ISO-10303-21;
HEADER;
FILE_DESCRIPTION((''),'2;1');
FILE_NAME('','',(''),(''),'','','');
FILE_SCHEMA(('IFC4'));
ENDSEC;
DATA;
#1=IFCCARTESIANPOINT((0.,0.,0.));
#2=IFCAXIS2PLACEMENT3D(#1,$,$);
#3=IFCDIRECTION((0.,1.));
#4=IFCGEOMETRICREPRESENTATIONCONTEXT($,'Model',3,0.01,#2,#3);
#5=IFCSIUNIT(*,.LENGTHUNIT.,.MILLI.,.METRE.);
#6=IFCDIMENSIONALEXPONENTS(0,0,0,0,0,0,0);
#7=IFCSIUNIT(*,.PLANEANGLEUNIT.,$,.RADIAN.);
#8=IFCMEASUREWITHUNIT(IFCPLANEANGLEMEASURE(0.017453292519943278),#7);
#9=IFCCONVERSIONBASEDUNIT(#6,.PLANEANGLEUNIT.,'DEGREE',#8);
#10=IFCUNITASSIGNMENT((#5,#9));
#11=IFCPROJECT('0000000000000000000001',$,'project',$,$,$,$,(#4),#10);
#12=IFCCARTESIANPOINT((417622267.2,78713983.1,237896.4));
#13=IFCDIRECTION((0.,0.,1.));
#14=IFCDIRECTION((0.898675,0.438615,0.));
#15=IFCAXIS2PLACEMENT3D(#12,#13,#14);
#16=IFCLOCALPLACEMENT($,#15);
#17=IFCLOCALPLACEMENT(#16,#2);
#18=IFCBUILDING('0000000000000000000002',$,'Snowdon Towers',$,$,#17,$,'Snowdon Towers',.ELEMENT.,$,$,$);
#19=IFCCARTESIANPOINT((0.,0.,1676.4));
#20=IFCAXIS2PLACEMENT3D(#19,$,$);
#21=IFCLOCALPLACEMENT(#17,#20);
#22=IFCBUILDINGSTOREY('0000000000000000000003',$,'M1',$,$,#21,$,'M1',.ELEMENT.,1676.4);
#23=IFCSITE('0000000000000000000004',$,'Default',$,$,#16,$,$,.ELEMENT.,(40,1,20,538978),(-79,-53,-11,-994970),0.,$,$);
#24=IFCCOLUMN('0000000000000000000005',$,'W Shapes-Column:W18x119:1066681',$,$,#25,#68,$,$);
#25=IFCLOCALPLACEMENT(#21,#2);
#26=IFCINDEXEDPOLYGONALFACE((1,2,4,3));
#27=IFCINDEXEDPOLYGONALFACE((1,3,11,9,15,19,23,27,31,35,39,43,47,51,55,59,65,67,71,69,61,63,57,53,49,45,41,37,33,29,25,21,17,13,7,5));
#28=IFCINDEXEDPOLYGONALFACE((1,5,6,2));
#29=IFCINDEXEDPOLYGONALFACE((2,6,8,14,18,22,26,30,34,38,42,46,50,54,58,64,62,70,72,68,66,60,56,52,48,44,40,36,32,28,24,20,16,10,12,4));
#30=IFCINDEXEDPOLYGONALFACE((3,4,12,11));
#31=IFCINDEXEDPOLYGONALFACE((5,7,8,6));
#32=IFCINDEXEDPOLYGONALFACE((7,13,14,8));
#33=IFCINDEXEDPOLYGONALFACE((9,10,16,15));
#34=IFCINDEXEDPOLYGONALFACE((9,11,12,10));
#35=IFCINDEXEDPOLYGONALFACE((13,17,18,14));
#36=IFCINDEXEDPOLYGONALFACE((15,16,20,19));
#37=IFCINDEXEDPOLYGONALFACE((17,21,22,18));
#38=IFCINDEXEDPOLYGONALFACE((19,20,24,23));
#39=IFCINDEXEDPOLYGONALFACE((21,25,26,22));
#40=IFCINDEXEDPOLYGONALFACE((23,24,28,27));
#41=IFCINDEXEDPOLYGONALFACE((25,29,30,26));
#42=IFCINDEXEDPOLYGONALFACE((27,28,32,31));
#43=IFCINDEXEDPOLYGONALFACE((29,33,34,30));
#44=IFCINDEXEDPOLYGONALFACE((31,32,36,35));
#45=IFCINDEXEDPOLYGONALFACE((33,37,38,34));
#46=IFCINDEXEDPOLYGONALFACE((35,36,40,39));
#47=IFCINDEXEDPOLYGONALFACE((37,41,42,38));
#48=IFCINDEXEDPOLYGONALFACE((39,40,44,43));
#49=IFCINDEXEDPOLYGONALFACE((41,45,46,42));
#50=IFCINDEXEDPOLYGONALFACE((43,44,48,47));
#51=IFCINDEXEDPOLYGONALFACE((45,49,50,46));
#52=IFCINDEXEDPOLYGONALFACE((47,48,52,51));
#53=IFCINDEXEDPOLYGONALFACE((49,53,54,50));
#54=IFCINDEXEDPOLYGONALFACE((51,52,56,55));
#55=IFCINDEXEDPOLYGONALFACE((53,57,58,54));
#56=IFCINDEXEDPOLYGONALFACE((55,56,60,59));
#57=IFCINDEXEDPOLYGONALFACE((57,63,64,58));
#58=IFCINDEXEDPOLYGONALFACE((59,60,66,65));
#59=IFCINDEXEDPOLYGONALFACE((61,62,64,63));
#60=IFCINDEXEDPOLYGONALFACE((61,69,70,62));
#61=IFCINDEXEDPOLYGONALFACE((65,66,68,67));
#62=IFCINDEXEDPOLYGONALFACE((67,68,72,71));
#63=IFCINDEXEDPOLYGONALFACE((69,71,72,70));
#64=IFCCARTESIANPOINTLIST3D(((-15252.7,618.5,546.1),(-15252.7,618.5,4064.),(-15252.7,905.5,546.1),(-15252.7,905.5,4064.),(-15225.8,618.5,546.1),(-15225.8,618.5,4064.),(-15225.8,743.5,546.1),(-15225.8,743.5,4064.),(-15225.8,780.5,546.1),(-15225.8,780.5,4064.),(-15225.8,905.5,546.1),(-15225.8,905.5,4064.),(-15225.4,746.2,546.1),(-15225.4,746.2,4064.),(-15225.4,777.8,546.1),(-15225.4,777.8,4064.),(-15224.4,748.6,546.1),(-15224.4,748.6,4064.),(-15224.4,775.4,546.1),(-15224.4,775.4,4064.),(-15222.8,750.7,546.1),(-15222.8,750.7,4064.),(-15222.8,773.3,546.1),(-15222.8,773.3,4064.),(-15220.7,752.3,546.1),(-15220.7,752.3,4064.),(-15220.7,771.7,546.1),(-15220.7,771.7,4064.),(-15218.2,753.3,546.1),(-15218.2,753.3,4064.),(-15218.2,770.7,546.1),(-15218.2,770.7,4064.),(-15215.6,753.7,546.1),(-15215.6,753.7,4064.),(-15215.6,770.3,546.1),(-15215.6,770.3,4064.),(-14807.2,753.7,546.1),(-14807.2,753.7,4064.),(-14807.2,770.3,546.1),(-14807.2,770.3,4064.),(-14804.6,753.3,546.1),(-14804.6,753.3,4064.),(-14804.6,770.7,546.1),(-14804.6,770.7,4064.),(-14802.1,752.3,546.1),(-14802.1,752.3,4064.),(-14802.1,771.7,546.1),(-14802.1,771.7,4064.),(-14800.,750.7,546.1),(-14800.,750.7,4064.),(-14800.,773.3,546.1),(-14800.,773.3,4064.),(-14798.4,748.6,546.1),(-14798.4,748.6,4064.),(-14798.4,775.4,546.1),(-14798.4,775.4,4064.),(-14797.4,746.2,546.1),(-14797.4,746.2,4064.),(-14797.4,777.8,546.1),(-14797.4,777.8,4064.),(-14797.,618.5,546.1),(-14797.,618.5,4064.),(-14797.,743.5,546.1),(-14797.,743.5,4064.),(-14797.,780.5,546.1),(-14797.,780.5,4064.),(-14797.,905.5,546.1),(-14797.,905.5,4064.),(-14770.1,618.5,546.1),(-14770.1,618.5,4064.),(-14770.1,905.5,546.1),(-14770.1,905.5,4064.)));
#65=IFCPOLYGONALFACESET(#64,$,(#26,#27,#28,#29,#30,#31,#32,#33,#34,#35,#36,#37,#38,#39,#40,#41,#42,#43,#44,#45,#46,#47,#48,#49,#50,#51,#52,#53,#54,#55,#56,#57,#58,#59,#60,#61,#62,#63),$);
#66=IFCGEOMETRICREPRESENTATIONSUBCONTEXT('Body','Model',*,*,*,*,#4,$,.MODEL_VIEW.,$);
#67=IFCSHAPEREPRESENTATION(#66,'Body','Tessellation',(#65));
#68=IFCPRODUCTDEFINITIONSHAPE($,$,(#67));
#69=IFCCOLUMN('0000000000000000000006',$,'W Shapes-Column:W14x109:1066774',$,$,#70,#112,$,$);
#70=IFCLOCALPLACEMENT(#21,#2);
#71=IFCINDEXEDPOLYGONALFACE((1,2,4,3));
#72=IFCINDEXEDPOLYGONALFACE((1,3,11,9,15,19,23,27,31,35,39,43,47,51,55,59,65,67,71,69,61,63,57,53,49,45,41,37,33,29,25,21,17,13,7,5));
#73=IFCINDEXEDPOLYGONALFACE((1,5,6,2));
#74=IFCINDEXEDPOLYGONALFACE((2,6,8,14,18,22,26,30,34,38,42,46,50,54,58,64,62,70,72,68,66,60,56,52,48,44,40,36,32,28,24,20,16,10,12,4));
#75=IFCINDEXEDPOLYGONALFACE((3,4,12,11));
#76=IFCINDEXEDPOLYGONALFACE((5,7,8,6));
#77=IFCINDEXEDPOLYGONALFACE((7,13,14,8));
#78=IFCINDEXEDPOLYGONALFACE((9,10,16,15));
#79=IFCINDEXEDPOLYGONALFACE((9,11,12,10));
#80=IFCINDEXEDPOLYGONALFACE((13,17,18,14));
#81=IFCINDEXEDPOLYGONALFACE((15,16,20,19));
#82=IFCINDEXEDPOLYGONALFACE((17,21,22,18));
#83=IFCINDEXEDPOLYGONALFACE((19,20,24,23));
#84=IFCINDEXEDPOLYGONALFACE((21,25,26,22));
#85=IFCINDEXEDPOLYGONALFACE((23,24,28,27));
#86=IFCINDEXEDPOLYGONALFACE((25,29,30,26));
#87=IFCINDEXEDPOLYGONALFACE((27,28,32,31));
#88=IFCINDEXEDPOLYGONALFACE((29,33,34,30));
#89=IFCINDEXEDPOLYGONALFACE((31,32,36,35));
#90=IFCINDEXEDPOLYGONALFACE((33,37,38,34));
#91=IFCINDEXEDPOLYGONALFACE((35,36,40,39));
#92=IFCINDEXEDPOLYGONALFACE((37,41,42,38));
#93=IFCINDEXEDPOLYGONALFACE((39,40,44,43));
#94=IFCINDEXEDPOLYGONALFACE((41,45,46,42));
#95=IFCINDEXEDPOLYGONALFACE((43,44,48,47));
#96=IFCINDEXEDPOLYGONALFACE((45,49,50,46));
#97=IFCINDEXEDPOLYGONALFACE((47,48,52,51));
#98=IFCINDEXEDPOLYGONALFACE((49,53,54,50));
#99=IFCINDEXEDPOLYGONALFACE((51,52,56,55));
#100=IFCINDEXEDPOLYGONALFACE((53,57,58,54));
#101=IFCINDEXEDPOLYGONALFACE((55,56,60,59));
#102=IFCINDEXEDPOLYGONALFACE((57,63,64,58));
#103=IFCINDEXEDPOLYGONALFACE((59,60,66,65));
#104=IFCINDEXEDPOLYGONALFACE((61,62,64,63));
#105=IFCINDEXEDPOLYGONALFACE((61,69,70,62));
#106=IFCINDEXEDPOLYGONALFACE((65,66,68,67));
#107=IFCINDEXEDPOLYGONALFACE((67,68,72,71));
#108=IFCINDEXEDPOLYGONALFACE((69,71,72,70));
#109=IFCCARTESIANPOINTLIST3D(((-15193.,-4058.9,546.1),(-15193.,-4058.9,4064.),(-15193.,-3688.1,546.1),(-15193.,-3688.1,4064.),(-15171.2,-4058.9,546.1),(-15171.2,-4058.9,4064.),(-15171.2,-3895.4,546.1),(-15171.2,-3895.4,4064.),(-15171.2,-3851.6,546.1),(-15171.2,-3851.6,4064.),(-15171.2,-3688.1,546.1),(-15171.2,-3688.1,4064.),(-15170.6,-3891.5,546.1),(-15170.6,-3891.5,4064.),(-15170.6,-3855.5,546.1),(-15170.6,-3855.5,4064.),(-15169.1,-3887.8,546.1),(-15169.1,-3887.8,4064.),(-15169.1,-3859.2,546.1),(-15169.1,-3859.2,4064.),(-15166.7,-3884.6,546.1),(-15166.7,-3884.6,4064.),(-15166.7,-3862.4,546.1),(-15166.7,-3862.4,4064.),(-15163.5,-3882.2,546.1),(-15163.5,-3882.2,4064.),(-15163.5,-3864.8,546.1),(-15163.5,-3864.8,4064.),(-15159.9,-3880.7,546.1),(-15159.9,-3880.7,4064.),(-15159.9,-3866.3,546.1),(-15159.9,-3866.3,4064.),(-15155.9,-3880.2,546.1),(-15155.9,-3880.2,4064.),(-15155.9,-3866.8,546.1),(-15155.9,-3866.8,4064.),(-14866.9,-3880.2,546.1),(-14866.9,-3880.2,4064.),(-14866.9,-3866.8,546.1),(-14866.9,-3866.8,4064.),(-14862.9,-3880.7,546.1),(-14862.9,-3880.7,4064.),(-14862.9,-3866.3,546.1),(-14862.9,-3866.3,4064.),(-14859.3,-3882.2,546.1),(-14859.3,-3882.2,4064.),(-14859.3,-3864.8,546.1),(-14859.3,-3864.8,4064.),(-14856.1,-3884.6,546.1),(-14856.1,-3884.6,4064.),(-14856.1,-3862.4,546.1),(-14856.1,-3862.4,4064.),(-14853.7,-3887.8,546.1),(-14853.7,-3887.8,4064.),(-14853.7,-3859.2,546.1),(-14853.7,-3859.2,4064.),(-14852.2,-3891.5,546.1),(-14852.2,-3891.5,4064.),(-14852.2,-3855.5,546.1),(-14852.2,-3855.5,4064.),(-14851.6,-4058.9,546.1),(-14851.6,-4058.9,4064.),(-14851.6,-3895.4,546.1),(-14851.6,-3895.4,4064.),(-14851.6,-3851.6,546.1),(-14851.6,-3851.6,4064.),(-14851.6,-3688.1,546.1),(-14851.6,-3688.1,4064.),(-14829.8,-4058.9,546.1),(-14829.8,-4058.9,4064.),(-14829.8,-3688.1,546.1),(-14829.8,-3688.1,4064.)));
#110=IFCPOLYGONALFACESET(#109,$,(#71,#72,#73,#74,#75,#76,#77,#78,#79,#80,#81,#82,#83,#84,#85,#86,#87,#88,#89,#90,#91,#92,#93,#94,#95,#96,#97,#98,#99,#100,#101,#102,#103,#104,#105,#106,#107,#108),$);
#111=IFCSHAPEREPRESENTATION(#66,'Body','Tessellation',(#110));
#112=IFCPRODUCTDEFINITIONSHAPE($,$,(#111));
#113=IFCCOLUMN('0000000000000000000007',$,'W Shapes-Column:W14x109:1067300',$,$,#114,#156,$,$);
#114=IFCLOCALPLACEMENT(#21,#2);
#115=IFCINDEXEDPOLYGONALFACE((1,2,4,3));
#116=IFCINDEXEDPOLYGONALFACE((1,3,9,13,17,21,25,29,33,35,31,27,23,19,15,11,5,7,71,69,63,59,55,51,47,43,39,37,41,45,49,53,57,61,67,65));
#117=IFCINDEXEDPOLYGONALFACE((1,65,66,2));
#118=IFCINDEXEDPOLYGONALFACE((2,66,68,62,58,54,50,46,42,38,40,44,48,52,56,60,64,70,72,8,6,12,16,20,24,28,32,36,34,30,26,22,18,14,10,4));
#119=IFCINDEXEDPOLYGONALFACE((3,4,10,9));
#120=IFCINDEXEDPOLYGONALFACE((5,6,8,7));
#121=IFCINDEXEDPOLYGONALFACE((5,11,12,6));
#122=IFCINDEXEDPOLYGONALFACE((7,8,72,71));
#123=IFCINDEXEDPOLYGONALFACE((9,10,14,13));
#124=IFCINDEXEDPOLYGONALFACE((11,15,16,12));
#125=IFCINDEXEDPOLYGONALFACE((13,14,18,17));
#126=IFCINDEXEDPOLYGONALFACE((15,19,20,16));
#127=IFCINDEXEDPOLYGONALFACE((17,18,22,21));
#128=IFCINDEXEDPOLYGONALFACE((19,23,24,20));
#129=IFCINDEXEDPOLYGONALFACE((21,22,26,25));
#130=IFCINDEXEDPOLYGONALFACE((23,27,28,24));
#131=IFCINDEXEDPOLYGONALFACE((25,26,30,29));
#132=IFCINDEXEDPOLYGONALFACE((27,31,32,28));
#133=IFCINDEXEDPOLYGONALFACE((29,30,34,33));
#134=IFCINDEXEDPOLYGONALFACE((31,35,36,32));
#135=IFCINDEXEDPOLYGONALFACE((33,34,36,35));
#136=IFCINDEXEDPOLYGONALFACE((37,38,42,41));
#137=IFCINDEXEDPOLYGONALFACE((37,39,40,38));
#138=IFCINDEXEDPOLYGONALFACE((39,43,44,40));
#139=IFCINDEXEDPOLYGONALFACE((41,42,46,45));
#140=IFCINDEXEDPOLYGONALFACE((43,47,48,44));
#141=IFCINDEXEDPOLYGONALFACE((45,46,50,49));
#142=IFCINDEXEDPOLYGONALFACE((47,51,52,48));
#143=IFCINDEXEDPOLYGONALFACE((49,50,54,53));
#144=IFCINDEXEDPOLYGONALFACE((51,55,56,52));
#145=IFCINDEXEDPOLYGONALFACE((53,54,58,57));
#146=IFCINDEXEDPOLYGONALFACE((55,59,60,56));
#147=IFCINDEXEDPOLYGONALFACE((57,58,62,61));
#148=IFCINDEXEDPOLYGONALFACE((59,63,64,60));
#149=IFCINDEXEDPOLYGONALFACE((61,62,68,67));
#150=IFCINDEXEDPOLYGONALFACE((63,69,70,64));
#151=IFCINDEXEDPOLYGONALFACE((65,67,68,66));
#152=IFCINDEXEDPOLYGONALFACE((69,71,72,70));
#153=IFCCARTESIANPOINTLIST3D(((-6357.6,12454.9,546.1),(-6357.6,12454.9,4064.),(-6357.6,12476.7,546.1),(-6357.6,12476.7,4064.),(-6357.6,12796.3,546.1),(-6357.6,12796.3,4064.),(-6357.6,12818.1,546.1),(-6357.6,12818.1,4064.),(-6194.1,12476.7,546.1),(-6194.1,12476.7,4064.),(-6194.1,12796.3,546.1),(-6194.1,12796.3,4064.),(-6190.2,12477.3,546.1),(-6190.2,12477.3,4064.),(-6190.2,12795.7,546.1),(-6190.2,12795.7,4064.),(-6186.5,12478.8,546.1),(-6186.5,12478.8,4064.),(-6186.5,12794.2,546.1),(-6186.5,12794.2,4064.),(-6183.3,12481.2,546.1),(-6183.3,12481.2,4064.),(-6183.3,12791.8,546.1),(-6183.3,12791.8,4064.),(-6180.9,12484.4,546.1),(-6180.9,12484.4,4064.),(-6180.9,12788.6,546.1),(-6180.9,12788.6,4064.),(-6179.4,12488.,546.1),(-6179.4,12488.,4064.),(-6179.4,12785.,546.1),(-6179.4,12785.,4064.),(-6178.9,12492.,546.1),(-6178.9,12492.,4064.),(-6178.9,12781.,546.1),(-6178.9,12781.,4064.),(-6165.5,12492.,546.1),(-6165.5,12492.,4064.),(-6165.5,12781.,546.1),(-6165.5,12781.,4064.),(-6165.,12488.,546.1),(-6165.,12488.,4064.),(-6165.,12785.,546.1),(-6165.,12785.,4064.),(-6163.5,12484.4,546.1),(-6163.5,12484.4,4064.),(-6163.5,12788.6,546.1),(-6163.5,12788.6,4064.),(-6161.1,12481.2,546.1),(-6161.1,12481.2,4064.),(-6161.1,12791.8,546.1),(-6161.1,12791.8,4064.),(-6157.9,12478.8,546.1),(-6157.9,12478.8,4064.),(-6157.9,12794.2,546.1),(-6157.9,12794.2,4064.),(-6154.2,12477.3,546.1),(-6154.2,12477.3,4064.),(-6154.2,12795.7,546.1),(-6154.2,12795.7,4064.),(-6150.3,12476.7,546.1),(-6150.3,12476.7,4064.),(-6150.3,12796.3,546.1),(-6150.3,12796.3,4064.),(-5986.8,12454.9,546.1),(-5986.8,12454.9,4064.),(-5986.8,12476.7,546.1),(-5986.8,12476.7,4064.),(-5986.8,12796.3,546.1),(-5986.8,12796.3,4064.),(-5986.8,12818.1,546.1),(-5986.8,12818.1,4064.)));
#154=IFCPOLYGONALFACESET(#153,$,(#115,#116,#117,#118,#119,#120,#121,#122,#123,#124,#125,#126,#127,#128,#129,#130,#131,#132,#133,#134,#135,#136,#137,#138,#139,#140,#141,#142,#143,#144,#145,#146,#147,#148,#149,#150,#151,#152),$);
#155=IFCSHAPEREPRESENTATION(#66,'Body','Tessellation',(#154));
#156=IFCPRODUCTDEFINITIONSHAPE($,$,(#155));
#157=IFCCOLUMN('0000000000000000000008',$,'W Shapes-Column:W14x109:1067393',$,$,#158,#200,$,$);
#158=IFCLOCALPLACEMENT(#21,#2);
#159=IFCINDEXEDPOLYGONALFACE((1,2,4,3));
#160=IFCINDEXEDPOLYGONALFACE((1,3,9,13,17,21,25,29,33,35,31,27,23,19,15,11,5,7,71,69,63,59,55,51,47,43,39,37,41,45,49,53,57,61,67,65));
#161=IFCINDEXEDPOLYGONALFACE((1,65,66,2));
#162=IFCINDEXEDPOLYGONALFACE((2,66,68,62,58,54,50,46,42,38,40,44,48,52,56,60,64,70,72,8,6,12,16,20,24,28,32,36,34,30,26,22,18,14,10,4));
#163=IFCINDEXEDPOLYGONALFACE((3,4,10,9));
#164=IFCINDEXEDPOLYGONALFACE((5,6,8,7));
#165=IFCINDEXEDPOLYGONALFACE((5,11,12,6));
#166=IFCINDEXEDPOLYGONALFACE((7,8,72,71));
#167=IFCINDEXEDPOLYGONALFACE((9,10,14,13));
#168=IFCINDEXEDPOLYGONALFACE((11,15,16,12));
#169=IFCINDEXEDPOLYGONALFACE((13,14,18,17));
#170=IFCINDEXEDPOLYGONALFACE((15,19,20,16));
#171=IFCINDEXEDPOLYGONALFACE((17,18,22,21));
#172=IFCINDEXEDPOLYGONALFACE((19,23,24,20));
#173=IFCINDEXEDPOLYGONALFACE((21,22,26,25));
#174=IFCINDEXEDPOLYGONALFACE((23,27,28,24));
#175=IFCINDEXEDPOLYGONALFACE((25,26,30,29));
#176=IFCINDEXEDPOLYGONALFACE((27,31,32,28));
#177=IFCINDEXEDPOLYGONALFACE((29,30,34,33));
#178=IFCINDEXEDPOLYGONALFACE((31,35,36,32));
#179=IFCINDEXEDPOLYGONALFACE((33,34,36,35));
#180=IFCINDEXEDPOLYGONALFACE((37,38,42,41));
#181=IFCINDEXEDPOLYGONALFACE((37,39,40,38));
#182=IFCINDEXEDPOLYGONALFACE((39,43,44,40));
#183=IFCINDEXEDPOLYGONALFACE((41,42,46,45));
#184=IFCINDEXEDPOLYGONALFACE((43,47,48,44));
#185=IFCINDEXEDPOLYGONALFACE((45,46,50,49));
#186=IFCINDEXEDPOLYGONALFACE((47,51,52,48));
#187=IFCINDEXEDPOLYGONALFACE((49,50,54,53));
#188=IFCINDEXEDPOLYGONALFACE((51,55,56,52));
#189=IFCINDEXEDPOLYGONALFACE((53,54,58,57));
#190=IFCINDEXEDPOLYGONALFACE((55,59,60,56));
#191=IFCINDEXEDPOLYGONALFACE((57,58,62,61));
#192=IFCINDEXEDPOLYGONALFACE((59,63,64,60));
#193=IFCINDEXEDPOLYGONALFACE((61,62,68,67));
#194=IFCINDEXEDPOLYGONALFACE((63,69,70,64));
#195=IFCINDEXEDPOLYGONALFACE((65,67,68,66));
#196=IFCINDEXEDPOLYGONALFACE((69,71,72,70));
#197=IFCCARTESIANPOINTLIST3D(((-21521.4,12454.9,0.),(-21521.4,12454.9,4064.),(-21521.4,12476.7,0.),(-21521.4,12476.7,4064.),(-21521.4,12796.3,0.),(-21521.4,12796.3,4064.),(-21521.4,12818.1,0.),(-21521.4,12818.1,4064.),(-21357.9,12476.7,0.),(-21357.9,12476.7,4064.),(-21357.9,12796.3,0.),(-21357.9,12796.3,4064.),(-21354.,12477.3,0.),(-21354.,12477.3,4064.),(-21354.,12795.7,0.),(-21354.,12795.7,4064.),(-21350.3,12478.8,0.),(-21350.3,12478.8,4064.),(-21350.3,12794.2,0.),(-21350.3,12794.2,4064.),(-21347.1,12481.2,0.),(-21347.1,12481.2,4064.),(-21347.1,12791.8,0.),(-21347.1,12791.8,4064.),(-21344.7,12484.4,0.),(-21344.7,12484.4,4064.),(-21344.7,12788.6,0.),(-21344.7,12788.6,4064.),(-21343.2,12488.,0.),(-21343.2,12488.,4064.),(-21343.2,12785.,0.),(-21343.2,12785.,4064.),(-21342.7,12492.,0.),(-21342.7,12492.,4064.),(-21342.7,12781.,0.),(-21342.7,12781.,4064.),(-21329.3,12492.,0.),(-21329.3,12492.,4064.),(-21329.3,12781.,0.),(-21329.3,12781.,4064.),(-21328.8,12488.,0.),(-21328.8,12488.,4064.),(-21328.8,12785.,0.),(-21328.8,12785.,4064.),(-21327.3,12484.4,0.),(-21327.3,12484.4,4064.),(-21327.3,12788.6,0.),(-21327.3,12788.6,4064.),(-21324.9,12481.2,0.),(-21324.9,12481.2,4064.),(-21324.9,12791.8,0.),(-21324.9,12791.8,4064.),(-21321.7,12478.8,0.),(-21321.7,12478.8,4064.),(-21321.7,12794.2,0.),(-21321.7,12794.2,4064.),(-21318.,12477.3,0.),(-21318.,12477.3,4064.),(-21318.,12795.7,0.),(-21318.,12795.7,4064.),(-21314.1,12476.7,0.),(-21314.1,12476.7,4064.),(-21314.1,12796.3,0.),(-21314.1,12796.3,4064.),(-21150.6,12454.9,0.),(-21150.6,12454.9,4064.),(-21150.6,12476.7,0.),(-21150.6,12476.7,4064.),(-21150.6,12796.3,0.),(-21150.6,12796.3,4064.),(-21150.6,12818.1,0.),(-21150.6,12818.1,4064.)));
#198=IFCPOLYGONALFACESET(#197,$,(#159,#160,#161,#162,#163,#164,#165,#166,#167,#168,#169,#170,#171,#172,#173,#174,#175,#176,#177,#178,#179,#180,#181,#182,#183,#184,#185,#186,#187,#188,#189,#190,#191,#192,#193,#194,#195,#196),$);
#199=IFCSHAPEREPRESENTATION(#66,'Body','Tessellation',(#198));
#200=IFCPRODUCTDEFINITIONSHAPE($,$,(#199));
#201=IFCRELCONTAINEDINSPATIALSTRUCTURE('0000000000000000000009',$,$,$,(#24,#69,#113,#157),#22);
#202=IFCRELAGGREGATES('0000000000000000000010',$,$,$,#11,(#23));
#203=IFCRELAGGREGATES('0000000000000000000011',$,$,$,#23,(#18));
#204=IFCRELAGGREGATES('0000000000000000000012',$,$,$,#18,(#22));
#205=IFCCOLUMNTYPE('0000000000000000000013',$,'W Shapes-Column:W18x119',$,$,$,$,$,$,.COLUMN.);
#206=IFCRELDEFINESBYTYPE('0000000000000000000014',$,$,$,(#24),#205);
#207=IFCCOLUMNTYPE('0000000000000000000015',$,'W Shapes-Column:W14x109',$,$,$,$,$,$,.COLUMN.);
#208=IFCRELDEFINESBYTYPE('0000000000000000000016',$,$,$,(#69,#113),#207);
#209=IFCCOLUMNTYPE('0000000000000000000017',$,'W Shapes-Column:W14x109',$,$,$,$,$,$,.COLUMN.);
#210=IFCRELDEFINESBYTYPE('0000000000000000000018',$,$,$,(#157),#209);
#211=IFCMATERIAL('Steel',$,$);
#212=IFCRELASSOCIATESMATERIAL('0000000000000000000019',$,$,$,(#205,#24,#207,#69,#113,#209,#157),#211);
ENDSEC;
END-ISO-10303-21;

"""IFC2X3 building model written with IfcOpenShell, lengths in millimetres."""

from ifc_helpers import new_model, entity, si_unit, converted_unit, direction, frame, frame_2d, origin, place, context, subcontext, project, spatial, i_section, extrude, source, transform, mapped, material, type_object, type_shapes, element, save


model = new_model("IFC2X3")

# Units and contexts
model_context = context("Model", 3, precision=0.01, world=origin(), true_north=direction((0.0, 1.0)))
body_context = subcontext(model_context, "Body", "Model", "MODEL_VIEW")
ifc_project = project(units=[si_unit("LENGTHUNIT", "METRE", prefix="MILLI"), converted_unit("PLANEANGLEUNIT", "DEGREE", entity("IfcPlaneAngleMeasure", 0.017453292519943278), si_unit("PLANEANGLEUNIT", "RADIAN"), dimensions=[0, 0, 0, 0, 0, 0, 0])], contexts=[model_context])

# Site, building, storey
site_placement = place(None, frame((417622267.2, 78713983.1, 237896.4), z_axis=(0.0, 0.0, 1.0), x_axis=(0.898675, 0.438615, 0.0)))
site = spatial("IfcSite", under=ifc_project, at=site_placement, Name="Default", CompositionType="ELEMENT", RefLatitude=(40, 1, 20, 538978), RefLongitude=(-79, -53, -11, -994970), RefElevation=0.0)
building_placement = place(site_placement, origin())
building = spatial("IfcBuilding", under=site, at=building_placement, Name="Snowdon Towers", LongName="Snowdon Towers", CompositionType="ELEMENT")
storey_placement = place(building_placement, frame((0.0, 0.0, 1676.4)))
storey = spatial("IfcBuildingStorey", under=building, at=storey_placement, Name="M1", LongName="M1", CompositionType="ELEMENT", Elevation=1676.4)

# Columns
ifc_material_1 = material(Name="Steel")
column_type_1 = type_object("IfcColumnType", Name="W Shapes-Column:W18x119", PredefinedType="COLUMN", material=ifc_material_1)
shared_shape_1 = source(origin(), body_context, "Body", "SweptSolid", [
    extrude(i_section(OverallWidth=287.0, OverallDepth=482.6, WebThickness=16.6, FlangeThickness=26.9, FilletRadius=10.2, at=frame_2d((0.0, 0.0), x_axis=(1.0, 0.0))), frame((0.0, 0.0, 2222.5), z_axis=(0.0, 0.0, 1.0), x_axis=(-1.0, 0.0, 0.0)), (0.0, 0.0, 1.0), 3517.9),
])
type_shapes(column_type_1, [shared_shape_1])
column_placement = place(storey_placement, frame((-15011.4, 762.0, -1676.4), z_axis=(0.0, 0.0, 1.0), x_axis=(0.0, -1.0, 0.0)))
element("IfcColumn", 1, at=column_placement, inside=storey, type_object=column_type_1, material=ifc_material_1, Name="W Shapes-Column:W18x119:1066681", context=body_context, shape_type="MappedRepresentation", body=[
    mapped(shared_shape_1, transform((0.0, 0.0, 0.0), scale=1.0)),
])
column_type_2 = type_object("IfcColumnType", Name="W Shapes-Column:W14x109", PredefinedType="COLUMN", material=ifc_material_1)
shared_shape_2 = source(origin(), body_context, "Body", "SweptSolid", [
    extrude(i_section(OverallWidth=370.8, OverallDepth=363.2, WebThickness=13.3, FlangeThickness=21.8, FilletRadius=15.2, at=frame_2d((0.0, 0.0), x_axis=(1.0, 0.0))), frame((0.0, 0.0, 2222.5), z_axis=(0.0, 0.0, 1.0), x_axis=(-1.0, 0.0, 0.0)), (0.0, 0.0, 1.0), 3517.9),
])
type_shapes(column_type_2, [shared_shape_2])
for number, where, z_axis, x_axis, name in (
    (2, (-15011.4, -3873.5, -1676.4), (0.0, 0.0, 1.0), (0.0, 1.0, 0.0), "W Shapes-Column:W14x109:1066774"),
    (3, (-6172.2, 12636.5, -1676.4), (0.0, 0.0, 1.0), (-1.0, 0.0, 0.0), "W Shapes-Column:W14x109:1067300"),
):
    element("IfcColumn", number, at=place(storey_placement, frame(where, z_axis=z_axis, x_axis=x_axis)), inside=storey, type_object=column_type_2, material=ifc_material_1, Name=name, context=body_context, shape_type="MappedRepresentation", body=[
        mapped(shared_shape_2, transform((0.0, 0.0, 0.0), scale=1.0)),
    ])
column_type_3 = type_object("IfcColumnType", Name="W Shapes-Column:W14x109", PredefinedType="COLUMN", material=ifc_material_1)
shared_shape_3 = source(origin(), body_context, "Body", "SweptSolid", [
    extrude(i_section(OverallWidth=370.8, OverallDepth=363.2, WebThickness=13.3, FlangeThickness=21.8, FilletRadius=15.2, at=frame_2d((0.0, 0.0), x_axis=(1.0, 0.0))), frame((0.0, 0.0, 1676.4), z_axis=(0.0, 0.0, 1.0), x_axis=(-1.0, 0.0, 0.0)), (0.0, 0.0, 1.0), 4064.0),
])
type_shapes(column_type_3, [shared_shape_3])
for number, where, z_axis, x_axis, name in (
    (4, (-21336.0, 12636.5, -1676.4), (0.0, 0.0, 1.0), (-1.0, 0.0, 0.0), "W Shapes-Column:W14x109:1067393"),
):
    element("IfcColumn", number, at=place(storey_placement, frame(where, z_axis=z_axis, x_axis=x_axis)), inside=storey, type_object=column_type_3, material=ifc_material_1, Name=name, context=body_context, shape_type="MappedRepresentation", body=[
        mapped(shared_shape_3, transform((0.0, 0.0, 0.0), scale=1.0)),
    ])

save(model, "model.ifc")
